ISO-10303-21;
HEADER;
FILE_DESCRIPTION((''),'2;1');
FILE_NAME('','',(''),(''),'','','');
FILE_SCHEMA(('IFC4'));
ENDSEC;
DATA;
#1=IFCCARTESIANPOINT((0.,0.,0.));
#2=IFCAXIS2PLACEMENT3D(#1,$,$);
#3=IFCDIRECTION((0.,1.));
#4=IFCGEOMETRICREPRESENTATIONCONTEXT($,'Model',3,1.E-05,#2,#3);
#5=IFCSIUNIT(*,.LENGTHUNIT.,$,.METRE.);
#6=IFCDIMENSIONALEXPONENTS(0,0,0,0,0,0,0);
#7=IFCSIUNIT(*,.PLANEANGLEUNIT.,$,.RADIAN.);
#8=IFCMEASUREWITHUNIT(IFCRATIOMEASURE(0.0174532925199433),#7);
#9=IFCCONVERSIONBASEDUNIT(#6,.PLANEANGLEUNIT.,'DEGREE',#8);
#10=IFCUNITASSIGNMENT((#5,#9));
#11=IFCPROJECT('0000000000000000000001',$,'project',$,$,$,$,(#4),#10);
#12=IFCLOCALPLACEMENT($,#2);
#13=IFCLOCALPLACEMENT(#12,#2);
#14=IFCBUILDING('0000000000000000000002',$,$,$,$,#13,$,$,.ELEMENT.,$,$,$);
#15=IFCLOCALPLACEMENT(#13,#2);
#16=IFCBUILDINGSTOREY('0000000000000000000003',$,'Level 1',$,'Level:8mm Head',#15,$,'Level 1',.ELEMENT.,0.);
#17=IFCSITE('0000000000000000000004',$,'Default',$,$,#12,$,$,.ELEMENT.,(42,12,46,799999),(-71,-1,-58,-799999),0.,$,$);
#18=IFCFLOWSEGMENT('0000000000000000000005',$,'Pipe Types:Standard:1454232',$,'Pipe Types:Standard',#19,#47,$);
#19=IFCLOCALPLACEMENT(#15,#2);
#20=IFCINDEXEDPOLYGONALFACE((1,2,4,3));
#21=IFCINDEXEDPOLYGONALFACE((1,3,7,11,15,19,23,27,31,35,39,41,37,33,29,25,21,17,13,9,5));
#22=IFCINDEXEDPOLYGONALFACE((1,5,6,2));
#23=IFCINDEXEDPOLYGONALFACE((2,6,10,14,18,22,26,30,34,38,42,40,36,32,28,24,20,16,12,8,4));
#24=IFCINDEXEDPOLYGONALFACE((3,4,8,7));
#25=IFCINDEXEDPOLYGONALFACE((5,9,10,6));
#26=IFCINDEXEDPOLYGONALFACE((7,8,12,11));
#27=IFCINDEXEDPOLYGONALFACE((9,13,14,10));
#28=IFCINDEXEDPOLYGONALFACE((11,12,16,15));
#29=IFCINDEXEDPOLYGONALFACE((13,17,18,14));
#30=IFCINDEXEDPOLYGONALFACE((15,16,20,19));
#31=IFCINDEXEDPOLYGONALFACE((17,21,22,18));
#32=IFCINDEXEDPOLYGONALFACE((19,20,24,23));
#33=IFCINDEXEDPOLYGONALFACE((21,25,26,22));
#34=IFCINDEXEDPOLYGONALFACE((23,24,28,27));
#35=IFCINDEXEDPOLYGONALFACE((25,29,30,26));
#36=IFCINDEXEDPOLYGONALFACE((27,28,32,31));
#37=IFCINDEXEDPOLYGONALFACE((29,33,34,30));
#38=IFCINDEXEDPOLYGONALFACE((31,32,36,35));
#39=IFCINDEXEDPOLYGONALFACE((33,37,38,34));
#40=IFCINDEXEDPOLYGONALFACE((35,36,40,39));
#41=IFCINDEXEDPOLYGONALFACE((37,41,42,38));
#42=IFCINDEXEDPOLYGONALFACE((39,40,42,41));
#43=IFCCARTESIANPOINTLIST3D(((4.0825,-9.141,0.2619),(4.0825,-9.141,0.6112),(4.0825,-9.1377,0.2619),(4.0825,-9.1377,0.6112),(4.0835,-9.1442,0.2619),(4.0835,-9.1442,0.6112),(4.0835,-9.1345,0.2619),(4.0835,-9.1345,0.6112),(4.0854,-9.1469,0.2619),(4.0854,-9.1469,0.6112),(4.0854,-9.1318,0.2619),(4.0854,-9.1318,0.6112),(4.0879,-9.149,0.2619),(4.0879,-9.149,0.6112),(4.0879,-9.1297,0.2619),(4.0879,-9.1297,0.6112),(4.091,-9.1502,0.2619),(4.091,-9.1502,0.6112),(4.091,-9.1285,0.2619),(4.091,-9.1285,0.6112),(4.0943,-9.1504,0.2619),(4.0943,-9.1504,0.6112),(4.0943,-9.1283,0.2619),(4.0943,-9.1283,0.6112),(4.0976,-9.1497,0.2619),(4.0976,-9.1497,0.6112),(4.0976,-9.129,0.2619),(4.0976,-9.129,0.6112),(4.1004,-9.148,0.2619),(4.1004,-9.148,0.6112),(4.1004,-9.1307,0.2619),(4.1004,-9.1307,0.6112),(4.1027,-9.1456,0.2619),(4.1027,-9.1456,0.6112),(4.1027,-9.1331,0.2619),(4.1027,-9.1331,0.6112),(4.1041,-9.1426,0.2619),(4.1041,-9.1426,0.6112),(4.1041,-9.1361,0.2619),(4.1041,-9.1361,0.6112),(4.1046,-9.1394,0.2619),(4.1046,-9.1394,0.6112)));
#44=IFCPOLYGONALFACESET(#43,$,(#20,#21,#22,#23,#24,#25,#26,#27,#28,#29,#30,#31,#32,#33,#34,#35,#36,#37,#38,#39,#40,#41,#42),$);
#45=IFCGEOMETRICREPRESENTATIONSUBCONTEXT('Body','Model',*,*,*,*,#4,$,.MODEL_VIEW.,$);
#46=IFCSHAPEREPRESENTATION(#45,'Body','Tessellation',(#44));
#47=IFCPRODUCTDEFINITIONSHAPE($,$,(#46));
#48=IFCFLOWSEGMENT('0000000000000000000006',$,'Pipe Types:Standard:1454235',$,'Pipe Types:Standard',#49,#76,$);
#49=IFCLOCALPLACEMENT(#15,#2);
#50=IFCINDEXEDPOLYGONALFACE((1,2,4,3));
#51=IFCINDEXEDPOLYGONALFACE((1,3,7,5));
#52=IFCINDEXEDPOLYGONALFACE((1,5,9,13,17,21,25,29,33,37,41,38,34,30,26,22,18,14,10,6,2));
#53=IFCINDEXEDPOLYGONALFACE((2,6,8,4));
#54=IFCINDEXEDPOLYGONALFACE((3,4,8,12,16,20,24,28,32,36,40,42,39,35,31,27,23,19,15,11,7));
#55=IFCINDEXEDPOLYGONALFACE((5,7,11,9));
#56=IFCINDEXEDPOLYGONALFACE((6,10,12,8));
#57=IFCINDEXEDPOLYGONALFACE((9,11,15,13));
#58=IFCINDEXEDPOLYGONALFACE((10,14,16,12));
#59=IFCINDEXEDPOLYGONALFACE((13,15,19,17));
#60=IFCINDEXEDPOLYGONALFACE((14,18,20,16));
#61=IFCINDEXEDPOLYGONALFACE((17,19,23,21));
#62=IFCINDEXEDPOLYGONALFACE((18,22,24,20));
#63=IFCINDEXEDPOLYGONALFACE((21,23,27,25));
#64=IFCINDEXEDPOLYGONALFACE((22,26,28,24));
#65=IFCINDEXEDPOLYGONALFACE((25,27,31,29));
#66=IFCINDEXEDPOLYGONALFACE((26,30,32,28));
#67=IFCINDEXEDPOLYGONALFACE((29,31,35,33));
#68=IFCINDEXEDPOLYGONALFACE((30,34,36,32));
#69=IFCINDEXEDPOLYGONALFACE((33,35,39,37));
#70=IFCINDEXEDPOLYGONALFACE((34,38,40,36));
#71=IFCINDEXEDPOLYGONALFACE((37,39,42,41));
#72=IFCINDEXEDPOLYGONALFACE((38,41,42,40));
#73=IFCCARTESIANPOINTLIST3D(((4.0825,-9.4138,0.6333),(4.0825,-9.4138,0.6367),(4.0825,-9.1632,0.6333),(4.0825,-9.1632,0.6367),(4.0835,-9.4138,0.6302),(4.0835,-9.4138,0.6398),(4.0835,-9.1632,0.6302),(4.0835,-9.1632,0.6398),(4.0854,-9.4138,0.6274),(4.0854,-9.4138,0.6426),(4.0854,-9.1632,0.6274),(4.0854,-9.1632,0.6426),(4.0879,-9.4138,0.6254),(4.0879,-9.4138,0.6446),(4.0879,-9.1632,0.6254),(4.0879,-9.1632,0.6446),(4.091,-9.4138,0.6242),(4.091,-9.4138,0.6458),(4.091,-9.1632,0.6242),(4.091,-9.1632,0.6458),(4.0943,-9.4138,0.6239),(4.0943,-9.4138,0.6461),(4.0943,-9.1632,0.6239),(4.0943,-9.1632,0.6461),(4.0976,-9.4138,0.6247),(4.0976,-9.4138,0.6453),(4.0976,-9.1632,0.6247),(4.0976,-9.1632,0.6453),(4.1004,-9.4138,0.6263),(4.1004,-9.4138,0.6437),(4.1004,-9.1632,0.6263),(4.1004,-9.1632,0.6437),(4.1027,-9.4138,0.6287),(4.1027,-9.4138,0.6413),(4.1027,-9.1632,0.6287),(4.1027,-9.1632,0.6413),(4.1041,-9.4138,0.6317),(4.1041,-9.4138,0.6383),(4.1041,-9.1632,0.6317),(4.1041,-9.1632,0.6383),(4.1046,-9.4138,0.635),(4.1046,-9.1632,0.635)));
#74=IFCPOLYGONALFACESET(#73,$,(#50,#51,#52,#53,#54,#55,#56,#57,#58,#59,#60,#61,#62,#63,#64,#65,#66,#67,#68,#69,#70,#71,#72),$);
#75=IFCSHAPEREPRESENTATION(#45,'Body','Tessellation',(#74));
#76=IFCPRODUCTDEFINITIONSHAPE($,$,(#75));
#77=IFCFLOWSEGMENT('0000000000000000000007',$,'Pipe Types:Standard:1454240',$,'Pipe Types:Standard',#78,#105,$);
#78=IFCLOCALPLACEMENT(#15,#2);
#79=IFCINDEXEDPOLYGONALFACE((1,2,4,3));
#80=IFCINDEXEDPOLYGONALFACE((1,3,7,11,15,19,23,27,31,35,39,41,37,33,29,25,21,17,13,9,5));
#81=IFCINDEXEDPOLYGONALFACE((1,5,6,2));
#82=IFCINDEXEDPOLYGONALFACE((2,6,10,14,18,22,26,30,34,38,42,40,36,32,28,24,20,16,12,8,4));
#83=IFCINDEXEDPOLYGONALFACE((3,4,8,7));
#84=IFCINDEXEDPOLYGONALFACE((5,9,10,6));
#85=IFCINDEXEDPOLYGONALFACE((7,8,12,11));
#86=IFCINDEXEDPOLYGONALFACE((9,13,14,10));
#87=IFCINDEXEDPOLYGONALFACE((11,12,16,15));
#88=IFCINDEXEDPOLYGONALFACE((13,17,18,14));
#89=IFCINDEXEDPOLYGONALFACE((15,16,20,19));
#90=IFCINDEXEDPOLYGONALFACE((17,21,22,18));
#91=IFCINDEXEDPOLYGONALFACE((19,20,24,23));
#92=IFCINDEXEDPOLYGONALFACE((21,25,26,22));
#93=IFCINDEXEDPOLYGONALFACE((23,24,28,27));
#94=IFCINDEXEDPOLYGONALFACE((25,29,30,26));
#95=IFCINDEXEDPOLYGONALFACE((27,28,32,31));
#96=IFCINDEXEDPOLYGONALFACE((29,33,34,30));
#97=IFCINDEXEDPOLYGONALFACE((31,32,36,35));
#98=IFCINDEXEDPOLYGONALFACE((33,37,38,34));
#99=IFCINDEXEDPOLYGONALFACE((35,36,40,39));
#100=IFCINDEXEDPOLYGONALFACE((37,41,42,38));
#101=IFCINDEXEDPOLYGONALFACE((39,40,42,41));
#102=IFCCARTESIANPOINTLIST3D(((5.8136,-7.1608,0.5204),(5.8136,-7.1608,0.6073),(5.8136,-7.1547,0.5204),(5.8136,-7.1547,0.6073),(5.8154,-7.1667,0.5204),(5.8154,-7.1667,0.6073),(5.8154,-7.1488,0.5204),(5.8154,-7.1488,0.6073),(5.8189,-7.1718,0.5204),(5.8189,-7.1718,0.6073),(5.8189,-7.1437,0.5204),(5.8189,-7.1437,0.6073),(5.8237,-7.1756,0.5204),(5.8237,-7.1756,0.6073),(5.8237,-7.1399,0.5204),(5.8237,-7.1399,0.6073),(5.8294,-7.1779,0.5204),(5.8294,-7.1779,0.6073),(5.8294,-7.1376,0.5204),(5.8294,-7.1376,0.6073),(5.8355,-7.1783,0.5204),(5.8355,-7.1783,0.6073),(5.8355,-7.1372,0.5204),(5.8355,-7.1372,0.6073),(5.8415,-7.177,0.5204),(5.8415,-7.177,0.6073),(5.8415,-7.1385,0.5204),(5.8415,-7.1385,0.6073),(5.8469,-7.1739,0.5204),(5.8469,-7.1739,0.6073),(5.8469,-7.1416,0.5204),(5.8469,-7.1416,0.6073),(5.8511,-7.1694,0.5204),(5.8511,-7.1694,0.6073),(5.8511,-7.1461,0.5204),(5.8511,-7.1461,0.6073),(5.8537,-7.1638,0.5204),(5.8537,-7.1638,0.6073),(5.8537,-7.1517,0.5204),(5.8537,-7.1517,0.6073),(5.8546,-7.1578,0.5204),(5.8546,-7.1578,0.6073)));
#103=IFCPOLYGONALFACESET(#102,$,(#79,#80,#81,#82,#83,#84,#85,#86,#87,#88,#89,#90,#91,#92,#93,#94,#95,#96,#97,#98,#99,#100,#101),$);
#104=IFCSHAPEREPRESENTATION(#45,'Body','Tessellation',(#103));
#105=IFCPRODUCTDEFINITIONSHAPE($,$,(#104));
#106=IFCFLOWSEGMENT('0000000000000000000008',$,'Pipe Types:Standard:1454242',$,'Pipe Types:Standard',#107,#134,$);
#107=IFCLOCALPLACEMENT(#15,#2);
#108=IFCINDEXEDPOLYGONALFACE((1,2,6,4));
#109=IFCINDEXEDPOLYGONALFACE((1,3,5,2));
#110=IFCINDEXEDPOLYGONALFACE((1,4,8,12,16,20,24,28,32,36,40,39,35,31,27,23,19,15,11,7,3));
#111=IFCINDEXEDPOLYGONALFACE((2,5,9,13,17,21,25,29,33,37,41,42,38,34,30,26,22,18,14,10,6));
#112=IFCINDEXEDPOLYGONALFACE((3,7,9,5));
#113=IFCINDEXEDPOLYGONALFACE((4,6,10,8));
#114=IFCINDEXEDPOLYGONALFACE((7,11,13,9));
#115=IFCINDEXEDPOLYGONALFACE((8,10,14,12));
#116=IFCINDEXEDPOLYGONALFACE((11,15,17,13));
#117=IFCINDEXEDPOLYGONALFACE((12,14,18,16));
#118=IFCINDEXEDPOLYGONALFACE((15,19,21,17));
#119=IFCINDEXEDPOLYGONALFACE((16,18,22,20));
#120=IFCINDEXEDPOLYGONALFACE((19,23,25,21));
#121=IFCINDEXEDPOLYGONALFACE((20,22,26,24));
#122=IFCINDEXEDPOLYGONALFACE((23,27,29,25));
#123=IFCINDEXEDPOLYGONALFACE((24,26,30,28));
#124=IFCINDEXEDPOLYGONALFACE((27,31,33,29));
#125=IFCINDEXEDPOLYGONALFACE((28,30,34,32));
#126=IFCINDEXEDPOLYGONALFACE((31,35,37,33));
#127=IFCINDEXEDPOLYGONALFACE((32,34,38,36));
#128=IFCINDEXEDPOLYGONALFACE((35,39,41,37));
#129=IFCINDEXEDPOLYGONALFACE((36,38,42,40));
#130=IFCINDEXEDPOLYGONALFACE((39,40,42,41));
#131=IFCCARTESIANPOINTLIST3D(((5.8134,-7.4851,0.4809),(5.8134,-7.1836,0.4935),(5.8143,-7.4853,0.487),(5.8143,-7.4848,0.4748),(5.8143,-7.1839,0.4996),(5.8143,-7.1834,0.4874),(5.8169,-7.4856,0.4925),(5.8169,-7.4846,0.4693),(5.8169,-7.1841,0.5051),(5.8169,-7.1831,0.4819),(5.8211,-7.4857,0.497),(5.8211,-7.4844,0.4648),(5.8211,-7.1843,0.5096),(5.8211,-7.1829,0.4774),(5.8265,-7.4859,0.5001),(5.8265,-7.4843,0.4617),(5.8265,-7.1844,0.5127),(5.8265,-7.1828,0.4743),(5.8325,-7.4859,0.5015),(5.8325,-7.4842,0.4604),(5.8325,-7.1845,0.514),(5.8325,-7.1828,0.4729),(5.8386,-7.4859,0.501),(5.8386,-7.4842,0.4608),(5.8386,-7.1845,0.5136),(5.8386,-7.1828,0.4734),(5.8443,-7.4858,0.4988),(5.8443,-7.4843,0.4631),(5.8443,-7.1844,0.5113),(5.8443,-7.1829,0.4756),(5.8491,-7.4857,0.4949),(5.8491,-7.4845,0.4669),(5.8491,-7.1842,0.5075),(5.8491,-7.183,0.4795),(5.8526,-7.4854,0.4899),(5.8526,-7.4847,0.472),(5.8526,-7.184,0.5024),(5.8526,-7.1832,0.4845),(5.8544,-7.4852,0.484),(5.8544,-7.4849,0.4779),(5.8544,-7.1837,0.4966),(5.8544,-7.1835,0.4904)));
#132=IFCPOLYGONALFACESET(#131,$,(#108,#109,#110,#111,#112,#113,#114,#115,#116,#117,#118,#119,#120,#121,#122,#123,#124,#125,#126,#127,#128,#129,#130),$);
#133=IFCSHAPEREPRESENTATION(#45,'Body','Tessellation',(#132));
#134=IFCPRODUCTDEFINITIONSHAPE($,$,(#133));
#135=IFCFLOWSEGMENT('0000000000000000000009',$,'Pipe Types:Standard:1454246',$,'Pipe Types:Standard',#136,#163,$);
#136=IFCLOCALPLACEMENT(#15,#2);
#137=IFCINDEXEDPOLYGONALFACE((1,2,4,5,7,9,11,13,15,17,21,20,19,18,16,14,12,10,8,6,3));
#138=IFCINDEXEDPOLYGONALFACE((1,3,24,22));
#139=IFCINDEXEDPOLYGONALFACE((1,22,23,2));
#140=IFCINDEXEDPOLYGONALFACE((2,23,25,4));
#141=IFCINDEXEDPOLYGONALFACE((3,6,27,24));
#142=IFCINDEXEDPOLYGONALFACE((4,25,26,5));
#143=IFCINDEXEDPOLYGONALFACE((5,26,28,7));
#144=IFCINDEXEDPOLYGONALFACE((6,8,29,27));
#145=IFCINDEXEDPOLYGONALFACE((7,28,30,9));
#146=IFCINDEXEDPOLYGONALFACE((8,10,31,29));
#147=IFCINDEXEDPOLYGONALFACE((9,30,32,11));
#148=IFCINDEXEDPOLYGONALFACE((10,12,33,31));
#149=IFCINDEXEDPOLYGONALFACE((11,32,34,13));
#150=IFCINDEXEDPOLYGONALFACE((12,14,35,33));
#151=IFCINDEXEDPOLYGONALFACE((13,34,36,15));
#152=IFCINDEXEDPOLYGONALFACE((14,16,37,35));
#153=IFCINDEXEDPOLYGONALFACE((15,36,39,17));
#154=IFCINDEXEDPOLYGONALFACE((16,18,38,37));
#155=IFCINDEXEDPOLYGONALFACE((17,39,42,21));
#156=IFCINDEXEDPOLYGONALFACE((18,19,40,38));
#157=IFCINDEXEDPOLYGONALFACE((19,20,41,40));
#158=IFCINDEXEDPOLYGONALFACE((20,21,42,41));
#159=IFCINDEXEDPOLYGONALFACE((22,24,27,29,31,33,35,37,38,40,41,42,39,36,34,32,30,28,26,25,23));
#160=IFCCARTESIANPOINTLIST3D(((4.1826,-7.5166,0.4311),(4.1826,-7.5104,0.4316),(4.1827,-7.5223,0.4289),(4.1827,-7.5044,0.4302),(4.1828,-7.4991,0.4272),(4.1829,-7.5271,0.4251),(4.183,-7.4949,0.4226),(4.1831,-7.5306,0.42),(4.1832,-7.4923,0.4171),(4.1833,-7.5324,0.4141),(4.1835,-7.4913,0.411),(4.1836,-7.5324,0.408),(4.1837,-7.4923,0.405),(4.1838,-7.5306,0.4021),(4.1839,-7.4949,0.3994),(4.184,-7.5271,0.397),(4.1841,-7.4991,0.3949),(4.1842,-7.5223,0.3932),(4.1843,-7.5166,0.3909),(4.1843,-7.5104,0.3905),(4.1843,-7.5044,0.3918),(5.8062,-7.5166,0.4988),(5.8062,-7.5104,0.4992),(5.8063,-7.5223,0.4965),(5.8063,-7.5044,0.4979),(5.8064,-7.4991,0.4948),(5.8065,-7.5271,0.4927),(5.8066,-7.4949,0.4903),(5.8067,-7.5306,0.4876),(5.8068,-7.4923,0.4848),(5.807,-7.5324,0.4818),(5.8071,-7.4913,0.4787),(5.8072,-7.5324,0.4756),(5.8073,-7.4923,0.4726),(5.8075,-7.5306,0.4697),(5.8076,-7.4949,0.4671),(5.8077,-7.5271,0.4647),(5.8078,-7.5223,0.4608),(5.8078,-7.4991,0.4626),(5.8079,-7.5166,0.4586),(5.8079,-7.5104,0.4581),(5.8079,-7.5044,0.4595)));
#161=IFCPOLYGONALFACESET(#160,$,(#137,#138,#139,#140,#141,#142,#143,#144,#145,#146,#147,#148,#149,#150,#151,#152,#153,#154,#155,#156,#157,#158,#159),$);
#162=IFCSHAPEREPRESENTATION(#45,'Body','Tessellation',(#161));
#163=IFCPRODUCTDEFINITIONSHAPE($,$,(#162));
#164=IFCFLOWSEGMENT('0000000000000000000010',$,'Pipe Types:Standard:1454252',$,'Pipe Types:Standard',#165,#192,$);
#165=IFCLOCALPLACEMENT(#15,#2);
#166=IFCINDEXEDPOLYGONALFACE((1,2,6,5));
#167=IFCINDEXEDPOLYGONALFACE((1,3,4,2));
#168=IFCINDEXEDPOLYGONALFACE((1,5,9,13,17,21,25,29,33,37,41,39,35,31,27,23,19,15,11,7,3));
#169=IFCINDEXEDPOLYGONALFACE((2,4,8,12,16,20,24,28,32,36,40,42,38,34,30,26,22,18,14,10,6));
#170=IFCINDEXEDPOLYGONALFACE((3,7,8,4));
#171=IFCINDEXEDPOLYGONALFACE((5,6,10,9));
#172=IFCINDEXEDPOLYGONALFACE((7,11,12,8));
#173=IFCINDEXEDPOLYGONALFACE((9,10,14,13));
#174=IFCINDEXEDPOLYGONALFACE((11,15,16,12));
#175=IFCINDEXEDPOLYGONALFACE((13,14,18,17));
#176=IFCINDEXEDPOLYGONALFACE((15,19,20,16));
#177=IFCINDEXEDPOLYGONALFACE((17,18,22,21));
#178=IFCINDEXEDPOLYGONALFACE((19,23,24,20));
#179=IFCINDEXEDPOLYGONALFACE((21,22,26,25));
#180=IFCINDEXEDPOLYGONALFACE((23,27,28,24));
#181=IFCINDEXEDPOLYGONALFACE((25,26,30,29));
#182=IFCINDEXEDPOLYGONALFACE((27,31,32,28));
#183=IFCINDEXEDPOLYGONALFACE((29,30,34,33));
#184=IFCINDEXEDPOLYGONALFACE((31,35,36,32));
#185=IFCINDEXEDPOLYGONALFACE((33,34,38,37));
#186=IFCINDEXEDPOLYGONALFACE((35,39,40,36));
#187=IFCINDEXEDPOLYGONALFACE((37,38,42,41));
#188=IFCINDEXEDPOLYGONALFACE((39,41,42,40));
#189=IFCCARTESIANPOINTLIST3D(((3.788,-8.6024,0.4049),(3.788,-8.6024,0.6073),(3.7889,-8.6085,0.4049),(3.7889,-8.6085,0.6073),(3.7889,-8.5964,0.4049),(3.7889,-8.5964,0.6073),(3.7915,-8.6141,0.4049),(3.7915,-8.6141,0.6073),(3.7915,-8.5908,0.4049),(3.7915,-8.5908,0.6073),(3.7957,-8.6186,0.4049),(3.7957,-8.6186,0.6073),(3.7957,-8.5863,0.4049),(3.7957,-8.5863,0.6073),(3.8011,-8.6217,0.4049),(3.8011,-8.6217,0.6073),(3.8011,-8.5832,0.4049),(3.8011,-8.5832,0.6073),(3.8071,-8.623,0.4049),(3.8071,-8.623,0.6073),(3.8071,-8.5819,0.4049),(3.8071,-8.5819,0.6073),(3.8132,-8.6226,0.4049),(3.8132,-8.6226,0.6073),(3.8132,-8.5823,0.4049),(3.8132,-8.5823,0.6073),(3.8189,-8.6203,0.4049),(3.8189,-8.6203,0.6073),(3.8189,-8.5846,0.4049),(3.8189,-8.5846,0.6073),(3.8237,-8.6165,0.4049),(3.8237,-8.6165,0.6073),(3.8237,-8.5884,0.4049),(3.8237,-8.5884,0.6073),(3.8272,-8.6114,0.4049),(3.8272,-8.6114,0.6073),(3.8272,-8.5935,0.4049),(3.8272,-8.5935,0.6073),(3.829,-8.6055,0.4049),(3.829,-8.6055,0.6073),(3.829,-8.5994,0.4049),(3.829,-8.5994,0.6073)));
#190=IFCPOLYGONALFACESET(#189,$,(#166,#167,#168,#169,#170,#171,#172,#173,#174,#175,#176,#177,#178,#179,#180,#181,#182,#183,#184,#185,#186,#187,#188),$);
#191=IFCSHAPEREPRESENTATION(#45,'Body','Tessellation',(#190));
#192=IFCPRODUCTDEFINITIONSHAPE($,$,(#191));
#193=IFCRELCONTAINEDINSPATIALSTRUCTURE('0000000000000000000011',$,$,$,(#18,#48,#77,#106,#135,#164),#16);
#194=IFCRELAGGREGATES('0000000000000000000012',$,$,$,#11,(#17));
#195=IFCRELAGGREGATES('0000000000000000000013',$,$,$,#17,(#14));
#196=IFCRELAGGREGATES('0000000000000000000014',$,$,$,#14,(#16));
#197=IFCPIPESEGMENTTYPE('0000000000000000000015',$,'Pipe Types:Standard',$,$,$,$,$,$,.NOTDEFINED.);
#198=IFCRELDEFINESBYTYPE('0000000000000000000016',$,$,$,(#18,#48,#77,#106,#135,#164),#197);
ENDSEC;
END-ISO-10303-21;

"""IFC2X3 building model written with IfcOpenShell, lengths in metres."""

from ifc_helpers import new_model, entity, si_unit, converted_unit, direction, frame, frame_2d, origin, origin_2d_with_axis, place, context, subcontext, project, spatial, circle, extrude, type_object, element, save


model = new_model("IFC2X3")

# Units and contexts
model_context = context("Model", 3, precision=1e-05, world=origin(), true_north=direction((0.0, 1.0)))
body_context = subcontext(model_context, "Body", "Model", "MODEL_VIEW")
ifc_project = project(units=[si_unit("LENGTHUNIT", "METRE"), converted_unit("PLANEANGLEUNIT", "DEGREE", entity("IfcRatioMeasure", 0.0174532925199433), si_unit("PLANEANGLEUNIT", "RADIAN"), dimensions=[0, 0, 0, 0, 0, 0, 0])], contexts=[model_context])

# Site, building, storey
site_placement = place(None, origin())
site = spatial("IfcSite", under=ifc_project, at=site_placement, Name="Default", CompositionType="ELEMENT", RefLatitude=(42, 12, 46, 799999), RefLongitude=(-71, -1, -58, -799999), RefElevation=0.0)
building_placement = place(site_placement, origin())
building = spatial("IfcBuilding", under=site, at=building_placement, CompositionType="ELEMENT")
storey_placement = place(building_placement, origin())
storey = spatial("IfcBuildingStorey", under=building, at=storey_placement, Name="Level 1", ObjectType="Level:8mm Head", LongName="Level 1", CompositionType="ELEMENT", Elevation=0.0)

# Flow segments
pipe_segment_type = type_object("IfcPipeSegmentType", Name="Pipe Types:Standard", PredefinedType="NOTDEFINED")
flow_segment_1_placement = place(storey_placement, origin())
element("IfcFlowSegment", 1, at=flow_segment_1_placement, inside=storey, type_object=pipe_segment_type, Name="Pipe Types:Standard:1454232", ObjectType="Pipe Types:Standard", context=body_context, shape_type="SweptSolid", body=[
    extrude(circle(Radius=0.0111, at=frame_2d((0.0, 0.0), x_axis=(1.0, 0.0))), frame((4.0935, -9.1394, 0.2619)), (0.0, 0.0, 1.0), 0.3493),
])
flow_segment_2_placement = place(storey_placement, origin())
element("IfcFlowSegment", 2, at=flow_segment_2_placement, inside=storey, type_object=pipe_segment_type, Name="Pipe Types:Standard:1454235", ObjectType="Pipe Types:Standard", context=body_context, shape_type="SweptSolid", body=[
    extrude(circle(Radius=0.0111, at=origin_2d_with_axis()), frame((4.0935, -9.4138, 0.635), z_axis=(0.0, 1.0, 0.0), x_axis=(1.0, 0.0, 0.0)), (0.0, 0.0, 1.0), 0.2506),
])
flow_segment_3_placement = place(storey_placement, origin())
element("IfcFlowSegment", 3, at=flow_segment_3_placement, inside=storey, type_object=pipe_segment_type, Name="Pipe Types:Standard:1454240", ObjectType="Pipe Types:Standard", context=body_context, shape_type="SweptSolid", body=[
    extrude(circle(Radius=0.0206, at=frame_2d((0.0, 0.0), x_axis=(1.0, 0.0))), frame((5.834, -7.1578, 0.5204)), (0.0, 0.0, 1.0), 0.0868),
])
flow_segment_4_placement = place(storey_placement, origin())
element("IfcFlowSegment", 4, at=flow_segment_4_placement, inside=storey, type_object=pipe_segment_type, Name="Pipe Types:Standard:1454242", ObjectType="Pipe Types:Standard", context=body_context, shape_type="SweptSolid", body=[
    extrude(circle(Radius=0.0206, at=frame_2d((0.0, 0.0), x_axis=(1.0, 0.0))), frame((5.834, -7.4851, 0.4809), z_axis=(0.0, 0.999133, 0.041631), x_axis=(-1.0, 0.0, 0.0)), (0.0, 0.0, 1.0), 0.3017),
])
flow_segment_5_placement = place(storey_placement, origin())
element("IfcFlowSegment", 5, at=flow_segment_5_placement, inside=storey, type_object=pipe_segment_type, Name="Pipe Types:Standard:1454246", ObjectType="Pipe Types:Standard", context=body_context, shape_type="SweptSolid", body=[
    extrude(circle(Radius=0.0206, at=frame_2d((0.0, 0.0), x_axis=(1.0, 0.0))), frame((4.1835, -7.512, 0.411), z_axis=(0.999133, 0.0, 0.041631), x_axis=(0.0, 1.0, 0.0)), (0.0, 0.0, 1.0), 1.625),
])
flow_segment_6_placement = place(storey_placement, origin())
element("IfcFlowSegment", 6, at=flow_segment_6_placement, inside=storey, type_object=pipe_segment_type, Name="Pipe Types:Standard:1454252", ObjectType="Pipe Types:Standard", context=body_context, shape_type="SweptSolid", body=[
    extrude(circle(Radius=0.0206, at=origin_2d_with_axis()), frame((3.8086, -8.6024, 0.4049), z_axis=(0.0, 0.0, 1.0), x_axis=(-1.0, 0.0, 0.0)), (0.0, 0.0, 1.0), 0.2024),
])

save(model, "model.ifc")
